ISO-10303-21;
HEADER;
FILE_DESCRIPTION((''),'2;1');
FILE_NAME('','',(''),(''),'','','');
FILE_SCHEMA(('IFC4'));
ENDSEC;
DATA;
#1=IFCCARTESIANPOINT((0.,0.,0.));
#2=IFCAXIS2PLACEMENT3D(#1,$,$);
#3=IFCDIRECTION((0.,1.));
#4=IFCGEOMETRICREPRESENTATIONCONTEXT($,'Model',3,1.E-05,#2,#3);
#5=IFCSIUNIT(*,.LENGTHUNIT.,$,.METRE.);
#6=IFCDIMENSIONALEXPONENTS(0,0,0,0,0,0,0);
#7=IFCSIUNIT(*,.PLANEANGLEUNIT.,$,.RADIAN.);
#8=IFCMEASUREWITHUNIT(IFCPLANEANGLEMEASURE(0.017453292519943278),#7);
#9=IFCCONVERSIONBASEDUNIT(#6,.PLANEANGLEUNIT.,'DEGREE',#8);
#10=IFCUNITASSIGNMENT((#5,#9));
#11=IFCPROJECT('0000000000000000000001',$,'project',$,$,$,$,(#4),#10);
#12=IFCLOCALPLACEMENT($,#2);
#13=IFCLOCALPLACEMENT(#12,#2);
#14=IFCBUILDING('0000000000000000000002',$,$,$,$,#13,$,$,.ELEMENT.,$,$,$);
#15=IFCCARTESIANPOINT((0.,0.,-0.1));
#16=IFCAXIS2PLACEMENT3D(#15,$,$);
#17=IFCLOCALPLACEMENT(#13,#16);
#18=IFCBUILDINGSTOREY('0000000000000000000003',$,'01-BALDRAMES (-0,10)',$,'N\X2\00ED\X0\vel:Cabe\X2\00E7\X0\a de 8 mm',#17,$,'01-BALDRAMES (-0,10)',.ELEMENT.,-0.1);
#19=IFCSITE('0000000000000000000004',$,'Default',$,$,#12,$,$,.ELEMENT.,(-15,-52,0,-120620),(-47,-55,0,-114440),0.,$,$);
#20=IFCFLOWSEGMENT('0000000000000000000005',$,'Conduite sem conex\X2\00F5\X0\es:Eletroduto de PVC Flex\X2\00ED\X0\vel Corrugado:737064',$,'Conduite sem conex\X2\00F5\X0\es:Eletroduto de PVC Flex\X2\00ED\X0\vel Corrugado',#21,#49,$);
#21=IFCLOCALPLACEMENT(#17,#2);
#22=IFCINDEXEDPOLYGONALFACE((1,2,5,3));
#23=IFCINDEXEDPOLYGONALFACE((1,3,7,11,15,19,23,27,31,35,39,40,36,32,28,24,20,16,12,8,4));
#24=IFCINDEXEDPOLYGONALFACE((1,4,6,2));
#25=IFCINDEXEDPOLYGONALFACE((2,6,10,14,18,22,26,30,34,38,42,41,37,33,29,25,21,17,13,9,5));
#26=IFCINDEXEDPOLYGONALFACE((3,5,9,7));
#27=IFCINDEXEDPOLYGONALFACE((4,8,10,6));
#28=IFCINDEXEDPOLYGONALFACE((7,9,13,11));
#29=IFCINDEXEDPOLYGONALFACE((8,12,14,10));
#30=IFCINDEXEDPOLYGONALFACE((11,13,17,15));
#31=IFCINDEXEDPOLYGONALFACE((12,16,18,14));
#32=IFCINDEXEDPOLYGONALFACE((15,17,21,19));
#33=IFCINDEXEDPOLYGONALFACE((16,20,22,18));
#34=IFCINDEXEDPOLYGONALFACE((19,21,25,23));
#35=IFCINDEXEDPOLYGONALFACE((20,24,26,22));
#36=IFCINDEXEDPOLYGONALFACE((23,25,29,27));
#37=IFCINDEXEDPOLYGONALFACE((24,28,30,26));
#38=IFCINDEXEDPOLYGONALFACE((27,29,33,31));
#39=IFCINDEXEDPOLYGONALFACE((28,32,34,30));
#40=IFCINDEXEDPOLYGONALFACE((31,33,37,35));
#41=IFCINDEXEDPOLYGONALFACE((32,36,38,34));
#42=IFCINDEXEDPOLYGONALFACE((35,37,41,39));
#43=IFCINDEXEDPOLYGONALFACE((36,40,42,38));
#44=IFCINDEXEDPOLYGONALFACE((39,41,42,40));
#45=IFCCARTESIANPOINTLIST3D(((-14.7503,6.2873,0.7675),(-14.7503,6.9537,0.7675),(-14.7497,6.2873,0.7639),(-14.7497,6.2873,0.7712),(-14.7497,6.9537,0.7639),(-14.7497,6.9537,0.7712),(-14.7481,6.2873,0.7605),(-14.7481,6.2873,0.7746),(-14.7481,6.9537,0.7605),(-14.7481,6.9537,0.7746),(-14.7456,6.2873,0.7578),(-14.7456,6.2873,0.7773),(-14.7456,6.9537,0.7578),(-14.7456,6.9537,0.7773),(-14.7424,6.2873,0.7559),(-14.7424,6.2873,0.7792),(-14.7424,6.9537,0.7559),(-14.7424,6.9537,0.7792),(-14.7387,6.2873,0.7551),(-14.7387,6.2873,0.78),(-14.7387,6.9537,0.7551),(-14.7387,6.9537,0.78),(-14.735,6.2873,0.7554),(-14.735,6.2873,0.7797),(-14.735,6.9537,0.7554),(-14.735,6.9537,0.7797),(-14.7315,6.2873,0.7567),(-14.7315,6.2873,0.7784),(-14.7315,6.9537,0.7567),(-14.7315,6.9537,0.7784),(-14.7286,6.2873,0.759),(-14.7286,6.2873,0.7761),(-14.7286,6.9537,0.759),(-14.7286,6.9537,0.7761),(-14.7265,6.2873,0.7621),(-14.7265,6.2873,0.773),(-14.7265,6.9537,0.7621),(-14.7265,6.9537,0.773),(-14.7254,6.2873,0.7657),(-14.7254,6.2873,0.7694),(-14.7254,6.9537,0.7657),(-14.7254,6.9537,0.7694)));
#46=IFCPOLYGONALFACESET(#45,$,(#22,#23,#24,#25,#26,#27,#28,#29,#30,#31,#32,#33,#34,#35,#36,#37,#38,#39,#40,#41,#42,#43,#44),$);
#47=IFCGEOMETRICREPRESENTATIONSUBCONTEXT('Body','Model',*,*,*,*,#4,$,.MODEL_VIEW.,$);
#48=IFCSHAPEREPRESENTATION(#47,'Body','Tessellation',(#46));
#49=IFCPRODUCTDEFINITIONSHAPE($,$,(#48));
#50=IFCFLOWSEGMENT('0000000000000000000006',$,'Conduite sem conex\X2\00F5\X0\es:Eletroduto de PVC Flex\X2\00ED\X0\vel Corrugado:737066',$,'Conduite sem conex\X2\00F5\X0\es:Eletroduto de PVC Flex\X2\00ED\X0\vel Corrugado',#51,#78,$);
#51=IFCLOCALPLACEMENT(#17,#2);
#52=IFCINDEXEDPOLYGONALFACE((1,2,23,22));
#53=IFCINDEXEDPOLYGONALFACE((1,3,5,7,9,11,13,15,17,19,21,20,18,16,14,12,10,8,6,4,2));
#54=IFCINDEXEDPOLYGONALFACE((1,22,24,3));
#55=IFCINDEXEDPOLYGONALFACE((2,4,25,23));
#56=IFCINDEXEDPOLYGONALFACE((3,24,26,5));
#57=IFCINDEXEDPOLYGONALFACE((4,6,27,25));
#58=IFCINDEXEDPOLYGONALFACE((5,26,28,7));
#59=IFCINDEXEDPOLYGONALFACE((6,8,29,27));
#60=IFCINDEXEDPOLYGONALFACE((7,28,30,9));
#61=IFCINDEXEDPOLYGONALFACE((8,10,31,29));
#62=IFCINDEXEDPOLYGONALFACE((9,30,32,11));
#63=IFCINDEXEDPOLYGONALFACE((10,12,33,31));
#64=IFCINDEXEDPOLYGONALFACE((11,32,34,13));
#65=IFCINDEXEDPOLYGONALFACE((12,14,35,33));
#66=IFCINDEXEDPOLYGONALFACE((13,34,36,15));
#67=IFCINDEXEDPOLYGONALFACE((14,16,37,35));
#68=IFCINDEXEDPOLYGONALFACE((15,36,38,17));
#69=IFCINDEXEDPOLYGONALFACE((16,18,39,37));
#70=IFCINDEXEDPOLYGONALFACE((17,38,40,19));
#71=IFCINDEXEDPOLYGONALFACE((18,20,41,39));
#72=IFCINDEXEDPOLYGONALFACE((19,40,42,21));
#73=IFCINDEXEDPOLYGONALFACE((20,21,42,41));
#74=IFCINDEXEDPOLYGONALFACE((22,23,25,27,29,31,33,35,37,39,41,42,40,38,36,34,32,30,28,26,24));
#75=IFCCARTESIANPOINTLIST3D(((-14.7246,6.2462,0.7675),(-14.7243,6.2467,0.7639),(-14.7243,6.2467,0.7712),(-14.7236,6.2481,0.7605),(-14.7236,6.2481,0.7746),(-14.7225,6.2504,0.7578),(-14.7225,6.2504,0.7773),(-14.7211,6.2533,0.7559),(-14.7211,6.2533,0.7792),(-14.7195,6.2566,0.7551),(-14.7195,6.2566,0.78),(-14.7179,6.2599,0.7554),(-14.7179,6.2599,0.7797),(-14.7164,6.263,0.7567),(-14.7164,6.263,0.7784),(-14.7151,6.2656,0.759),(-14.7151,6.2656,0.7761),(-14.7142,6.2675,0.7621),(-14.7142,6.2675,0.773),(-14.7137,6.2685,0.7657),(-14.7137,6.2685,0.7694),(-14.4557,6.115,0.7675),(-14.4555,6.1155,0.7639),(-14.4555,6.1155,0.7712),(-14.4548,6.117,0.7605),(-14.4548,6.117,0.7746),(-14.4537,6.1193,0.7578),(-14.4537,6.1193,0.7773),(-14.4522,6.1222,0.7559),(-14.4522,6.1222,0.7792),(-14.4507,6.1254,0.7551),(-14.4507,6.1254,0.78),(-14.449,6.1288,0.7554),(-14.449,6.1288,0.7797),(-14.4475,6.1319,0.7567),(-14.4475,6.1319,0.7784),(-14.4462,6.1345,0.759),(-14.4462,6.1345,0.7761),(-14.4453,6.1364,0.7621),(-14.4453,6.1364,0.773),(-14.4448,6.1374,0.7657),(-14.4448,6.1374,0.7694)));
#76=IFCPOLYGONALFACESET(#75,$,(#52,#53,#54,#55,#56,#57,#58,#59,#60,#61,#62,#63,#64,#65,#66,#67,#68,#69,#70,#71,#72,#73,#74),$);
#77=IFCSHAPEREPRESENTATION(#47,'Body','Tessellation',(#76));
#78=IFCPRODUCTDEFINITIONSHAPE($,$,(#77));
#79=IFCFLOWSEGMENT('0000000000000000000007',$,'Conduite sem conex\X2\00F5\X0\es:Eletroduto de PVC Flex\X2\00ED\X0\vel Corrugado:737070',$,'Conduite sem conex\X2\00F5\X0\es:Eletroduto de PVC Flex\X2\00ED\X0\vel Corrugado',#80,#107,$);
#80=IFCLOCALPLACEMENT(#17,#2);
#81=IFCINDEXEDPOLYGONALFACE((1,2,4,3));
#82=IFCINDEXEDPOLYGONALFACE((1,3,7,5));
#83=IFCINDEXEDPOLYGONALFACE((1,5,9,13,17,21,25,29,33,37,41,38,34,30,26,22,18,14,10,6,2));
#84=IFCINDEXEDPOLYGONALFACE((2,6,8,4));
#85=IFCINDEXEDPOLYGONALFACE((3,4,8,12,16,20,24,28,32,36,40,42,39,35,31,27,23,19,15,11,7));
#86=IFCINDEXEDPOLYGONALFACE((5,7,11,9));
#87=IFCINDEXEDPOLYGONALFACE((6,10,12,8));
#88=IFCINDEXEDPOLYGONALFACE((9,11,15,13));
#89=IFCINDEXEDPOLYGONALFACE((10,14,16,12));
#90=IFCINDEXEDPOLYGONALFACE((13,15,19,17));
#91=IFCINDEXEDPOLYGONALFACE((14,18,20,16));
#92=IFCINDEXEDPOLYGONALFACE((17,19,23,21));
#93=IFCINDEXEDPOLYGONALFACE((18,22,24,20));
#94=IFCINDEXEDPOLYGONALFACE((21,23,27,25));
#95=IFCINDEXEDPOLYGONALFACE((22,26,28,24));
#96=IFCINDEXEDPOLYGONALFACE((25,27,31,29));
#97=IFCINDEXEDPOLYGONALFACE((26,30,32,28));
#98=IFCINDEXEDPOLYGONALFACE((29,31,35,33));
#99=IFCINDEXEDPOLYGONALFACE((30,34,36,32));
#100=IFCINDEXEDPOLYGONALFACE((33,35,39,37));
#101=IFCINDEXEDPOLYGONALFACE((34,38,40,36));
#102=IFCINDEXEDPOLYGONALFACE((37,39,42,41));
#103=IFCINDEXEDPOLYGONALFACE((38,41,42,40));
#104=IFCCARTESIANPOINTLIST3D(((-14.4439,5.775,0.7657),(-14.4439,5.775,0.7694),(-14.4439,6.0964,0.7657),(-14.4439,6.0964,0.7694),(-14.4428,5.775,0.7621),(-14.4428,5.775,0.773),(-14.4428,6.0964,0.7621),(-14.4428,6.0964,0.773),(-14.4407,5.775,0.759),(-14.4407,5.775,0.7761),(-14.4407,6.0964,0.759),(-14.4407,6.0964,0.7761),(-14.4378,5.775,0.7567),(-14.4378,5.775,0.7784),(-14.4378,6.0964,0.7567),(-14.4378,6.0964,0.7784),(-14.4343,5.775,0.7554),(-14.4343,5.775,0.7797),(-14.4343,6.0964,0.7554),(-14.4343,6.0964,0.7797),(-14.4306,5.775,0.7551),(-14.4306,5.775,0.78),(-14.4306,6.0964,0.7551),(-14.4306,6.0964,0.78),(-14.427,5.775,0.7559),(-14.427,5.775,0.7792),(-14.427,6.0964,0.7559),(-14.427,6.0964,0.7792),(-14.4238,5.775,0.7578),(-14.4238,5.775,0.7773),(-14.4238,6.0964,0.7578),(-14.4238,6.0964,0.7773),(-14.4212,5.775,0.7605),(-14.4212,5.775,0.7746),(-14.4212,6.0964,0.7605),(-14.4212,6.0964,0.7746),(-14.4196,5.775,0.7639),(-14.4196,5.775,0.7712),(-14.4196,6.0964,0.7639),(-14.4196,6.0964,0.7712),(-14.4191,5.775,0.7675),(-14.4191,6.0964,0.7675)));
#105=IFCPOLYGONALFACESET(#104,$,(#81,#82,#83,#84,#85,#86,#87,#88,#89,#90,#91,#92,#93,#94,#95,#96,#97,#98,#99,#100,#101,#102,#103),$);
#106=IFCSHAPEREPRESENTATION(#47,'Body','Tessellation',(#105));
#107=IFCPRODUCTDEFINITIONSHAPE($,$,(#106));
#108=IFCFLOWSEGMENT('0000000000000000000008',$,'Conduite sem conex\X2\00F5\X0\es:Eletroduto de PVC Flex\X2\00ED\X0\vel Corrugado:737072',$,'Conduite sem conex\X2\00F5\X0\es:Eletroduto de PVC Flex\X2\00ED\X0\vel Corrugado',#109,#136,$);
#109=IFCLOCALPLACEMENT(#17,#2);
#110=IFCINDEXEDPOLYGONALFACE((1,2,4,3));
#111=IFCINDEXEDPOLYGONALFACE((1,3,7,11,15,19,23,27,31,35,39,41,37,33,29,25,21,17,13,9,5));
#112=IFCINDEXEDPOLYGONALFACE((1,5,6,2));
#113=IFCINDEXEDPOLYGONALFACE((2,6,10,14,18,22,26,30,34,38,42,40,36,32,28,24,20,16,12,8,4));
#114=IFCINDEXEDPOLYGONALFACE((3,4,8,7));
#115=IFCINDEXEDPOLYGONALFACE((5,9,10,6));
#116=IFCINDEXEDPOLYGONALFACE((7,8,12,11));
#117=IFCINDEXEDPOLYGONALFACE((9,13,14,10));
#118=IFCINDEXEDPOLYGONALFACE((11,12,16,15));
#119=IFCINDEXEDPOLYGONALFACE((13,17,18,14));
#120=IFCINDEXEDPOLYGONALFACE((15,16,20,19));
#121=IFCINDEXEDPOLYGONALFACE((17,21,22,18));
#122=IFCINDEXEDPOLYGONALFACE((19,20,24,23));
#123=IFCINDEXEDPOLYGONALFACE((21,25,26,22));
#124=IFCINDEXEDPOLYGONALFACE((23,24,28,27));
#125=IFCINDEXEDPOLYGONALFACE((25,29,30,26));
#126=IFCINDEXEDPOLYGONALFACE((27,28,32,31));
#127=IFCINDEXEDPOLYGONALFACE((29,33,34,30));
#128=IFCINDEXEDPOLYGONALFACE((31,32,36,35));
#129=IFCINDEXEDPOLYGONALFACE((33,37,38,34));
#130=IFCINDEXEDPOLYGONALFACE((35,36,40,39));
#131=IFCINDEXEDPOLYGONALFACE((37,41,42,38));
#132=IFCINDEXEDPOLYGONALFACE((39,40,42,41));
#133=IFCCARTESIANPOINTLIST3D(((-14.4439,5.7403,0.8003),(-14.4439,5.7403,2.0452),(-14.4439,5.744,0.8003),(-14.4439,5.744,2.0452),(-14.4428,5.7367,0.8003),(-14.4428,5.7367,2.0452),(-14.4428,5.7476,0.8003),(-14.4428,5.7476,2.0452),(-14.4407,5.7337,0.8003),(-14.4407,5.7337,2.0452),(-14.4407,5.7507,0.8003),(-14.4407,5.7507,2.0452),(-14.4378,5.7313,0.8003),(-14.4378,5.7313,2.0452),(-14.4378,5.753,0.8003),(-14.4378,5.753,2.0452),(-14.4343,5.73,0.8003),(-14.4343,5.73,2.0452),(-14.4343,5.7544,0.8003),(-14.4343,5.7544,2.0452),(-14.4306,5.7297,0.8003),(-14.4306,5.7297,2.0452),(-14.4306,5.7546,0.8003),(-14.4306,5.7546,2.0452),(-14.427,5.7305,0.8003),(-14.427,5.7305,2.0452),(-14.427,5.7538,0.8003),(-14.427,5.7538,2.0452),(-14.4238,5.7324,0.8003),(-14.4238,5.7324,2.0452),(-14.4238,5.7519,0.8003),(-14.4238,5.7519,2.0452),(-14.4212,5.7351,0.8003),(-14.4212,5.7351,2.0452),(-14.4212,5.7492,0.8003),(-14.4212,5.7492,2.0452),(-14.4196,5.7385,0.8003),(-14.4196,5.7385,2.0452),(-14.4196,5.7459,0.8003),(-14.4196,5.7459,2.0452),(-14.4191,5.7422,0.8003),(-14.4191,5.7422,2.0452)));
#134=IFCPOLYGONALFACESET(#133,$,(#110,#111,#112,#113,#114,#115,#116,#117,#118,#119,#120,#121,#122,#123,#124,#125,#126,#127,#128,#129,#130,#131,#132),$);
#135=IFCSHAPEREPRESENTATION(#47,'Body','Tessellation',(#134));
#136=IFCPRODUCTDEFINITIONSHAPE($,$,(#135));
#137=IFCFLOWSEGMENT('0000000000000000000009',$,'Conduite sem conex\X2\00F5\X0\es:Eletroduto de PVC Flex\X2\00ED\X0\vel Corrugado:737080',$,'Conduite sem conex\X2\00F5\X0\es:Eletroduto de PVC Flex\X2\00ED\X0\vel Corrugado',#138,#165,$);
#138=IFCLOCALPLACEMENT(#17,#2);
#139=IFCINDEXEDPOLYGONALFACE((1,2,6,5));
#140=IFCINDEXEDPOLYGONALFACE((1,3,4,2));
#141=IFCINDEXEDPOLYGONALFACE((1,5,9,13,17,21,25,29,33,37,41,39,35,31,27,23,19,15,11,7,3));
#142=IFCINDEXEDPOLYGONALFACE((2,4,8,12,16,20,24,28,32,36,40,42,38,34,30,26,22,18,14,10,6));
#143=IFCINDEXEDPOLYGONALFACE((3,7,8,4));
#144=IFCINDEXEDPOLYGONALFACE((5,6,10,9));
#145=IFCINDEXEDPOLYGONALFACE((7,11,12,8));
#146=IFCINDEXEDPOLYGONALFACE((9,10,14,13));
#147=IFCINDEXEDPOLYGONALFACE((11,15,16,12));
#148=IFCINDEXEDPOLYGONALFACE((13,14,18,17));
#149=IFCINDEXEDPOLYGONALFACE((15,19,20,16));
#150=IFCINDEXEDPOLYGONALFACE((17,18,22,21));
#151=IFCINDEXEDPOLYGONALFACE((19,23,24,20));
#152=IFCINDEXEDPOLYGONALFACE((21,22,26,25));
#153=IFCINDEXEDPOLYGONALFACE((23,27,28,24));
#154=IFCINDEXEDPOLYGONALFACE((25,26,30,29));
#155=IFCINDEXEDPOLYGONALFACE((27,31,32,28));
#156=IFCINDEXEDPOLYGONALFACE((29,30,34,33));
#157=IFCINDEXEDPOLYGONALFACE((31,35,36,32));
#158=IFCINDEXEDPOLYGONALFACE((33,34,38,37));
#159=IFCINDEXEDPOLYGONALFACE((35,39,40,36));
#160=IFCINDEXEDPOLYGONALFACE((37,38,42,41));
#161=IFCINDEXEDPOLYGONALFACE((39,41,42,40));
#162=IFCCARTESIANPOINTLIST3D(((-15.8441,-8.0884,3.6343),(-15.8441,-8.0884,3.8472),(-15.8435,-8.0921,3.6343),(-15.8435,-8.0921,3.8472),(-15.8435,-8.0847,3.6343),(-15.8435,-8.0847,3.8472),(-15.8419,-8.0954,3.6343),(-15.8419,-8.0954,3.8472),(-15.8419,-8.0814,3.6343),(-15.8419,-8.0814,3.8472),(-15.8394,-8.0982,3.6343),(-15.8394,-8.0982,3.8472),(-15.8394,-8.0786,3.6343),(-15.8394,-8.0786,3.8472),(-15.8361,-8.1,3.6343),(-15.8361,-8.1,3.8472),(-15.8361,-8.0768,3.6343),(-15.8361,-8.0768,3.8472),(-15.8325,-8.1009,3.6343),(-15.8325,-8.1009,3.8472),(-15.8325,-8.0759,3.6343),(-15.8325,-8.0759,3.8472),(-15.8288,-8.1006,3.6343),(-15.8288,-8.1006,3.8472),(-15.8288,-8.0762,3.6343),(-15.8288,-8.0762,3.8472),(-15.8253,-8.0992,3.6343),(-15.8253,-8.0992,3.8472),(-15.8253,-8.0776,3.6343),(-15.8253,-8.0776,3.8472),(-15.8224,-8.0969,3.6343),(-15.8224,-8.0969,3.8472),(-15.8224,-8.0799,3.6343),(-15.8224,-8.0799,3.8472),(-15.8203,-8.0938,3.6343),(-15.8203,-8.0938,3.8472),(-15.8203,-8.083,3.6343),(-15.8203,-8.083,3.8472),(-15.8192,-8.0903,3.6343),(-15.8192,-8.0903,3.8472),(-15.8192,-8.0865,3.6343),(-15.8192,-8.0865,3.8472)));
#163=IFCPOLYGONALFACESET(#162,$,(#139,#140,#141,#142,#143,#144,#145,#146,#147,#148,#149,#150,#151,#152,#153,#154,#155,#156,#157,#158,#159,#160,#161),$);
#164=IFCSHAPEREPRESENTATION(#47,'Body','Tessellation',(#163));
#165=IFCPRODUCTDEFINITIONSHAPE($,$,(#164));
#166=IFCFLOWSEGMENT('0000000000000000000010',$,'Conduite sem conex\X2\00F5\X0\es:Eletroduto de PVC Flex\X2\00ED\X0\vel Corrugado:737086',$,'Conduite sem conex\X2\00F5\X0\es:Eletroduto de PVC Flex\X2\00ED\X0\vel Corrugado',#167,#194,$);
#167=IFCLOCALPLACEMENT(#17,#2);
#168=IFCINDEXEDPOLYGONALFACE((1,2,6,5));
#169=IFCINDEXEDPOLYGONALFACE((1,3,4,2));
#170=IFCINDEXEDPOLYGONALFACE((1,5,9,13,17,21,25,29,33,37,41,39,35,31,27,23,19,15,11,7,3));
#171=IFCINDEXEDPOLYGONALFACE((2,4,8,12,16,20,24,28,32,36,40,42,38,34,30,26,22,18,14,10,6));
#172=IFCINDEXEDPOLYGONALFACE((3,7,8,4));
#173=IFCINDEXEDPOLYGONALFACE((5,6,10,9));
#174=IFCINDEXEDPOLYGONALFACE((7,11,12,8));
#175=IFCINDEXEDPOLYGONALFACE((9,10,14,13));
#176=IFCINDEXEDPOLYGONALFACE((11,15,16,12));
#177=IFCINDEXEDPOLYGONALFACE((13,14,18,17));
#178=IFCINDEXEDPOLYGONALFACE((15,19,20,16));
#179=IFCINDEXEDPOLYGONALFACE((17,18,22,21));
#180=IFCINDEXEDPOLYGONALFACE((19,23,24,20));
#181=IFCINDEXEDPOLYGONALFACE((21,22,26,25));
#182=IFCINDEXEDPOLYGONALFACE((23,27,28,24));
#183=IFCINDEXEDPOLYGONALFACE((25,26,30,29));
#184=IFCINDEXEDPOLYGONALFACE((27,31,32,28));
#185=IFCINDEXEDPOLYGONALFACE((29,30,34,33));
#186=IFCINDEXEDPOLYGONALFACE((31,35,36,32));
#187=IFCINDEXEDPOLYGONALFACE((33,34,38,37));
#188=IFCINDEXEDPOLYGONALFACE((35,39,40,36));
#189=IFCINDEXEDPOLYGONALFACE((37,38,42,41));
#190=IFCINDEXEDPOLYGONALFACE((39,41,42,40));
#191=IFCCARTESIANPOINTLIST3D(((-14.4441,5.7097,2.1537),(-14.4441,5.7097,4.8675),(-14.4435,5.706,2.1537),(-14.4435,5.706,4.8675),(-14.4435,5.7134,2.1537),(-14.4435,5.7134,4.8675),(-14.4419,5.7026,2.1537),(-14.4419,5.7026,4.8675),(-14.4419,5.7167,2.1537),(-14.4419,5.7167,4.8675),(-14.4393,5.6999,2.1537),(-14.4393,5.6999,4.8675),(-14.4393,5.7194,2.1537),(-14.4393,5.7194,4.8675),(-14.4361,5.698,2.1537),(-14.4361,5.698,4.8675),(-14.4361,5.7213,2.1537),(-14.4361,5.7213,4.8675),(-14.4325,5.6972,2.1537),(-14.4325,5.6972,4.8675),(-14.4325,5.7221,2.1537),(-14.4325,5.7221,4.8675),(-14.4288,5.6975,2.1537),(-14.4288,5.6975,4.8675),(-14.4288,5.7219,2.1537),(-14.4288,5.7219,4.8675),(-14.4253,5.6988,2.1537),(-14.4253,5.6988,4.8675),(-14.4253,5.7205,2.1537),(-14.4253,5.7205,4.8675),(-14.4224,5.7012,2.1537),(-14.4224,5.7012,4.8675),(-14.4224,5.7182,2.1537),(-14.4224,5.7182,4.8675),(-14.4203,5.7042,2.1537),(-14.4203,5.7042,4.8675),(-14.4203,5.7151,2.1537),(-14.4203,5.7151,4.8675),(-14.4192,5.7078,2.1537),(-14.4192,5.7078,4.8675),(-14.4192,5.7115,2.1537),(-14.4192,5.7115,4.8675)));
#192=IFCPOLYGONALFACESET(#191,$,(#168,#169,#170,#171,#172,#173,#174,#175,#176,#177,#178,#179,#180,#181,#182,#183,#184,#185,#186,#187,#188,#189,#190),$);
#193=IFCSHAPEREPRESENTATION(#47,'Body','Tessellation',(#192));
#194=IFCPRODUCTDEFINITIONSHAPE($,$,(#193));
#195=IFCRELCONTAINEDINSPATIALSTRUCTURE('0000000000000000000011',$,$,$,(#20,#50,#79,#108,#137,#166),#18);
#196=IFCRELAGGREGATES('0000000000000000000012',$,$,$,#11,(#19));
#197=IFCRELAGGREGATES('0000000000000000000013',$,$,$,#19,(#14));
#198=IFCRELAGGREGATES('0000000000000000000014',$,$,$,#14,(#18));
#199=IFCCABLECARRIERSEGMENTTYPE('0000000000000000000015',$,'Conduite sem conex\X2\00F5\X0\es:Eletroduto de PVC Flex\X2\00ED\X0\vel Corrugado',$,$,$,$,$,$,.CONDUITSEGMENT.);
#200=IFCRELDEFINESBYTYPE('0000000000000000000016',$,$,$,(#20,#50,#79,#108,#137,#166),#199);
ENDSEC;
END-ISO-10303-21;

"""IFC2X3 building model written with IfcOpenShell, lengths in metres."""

from ifc_helpers import new_model, entity, si_unit, converted_unit, direction, frame, frame_2d, origin, origin_2d_with_axis, place, context, subcontext, project, spatial, circle, extrude, type_object, element, save


model = new_model("IFC2X3")

# Units and contexts
model_context = context("Model", 3, precision=1e-05, world=origin(), true_north=direction((0.0, 1.0)))
body_context = subcontext(model_context, "Body", "Model", "MODEL_VIEW")
ifc_project = project(units=[si_unit("LENGTHUNIT", "METRE"), converted_unit("PLANEANGLEUNIT", "DEGREE", entity("IfcPlaneAngleMeasure", 0.017453292519943278), si_unit("PLANEANGLEUNIT", "RADIAN"), dimensions=[0, 0, 0, 0, 0, 0, 0])], contexts=[model_context])

# Site, building, storey
site_placement = place(None, origin())
site = spatial("IfcSite", under=ifc_project, at=site_placement, Name="Default", CompositionType="ELEMENT", RefLatitude=(-15, -52, 0, -120620), RefLongitude=(-47, -55, 0, -114440), RefElevation=0.0)
building_placement = place(site_placement, origin())
building = spatial("IfcBuilding", under=site, at=building_placement, CompositionType="ELEMENT")
storey_placement = place(building_placement, frame((0.0, 0.0, -0.1)))
storey = spatial("IfcBuildingStorey", under=building, at=storey_placement, Name="01-BALDRAMES (-0,10)", ObjectType="Nível:Cabeça de 8 mm", LongName="01-BALDRAMES (-0,10)", CompositionType="ELEMENT", Elevation=-0.1)

# Flow segments
cable_carrier_segment_type = type_object("IfcCableCarrierSegmentType", Name="Conduite sem conexões:Eletroduto de PVC Flexível Corrugado", PredefinedType="CONDUITSEGMENT")
flow_segment_1_placement = place(storey_placement, origin())
element("IfcFlowSegment", 1, at=flow_segment_1_placement, inside=storey, type_object=cable_carrier_segment_type, Name="Conduite sem conexões:Eletroduto de PVC Flexível Corrugado:737064", ObjectType="Conduite sem conexões:Eletroduto de PVC Flexível Corrugado", context=body_context, shape_type="SweptSolid", body=[
    extrude(circle(Radius=0.0125, at=frame_2d((0.0, 0.0), x_axis=(1.0, 0.0))), frame((-14.7378, 6.2873, 0.7675), z_axis=(0.0, 1.0, 0.0), x_axis=(-1.0, 0.0, 0.0)), (0.0, 0.0, 1.0), 0.6664),
])
flow_segment_2_placement = place(storey_placement, origin())
element("IfcFlowSegment", 2, at=flow_segment_2_placement, inside=storey, type_object=cable_carrier_segment_type, Name="Conduite sem conexões:Eletroduto de PVC Flexível Corrugado:737066", ObjectType="Conduite sem conexões:Eletroduto de PVC Flexível Corrugado", context=body_context, shape_type="SweptSolid", body=[
    extrude(circle(Radius=0.0125, at=origin_2d_with_axis()), frame((-14.4502, 6.1263, 0.7675), z_axis=(-0.898794, 0.438371, 0.0), x_axis=(-0.438371, -0.898794, 0.0)), (0.0, 0.0, 1.0), 0.2991),
])
flow_segment_3_placement = place(storey_placement, origin())
element("IfcFlowSegment", 3, at=flow_segment_3_placement, inside=storey, type_object=cable_carrier_segment_type, Name="Conduite sem conexões:Eletroduto de PVC Flexível Corrugado:737070", ObjectType="Conduite sem conexões:Eletroduto de PVC Flexível Corrugado", context=body_context, shape_type="SweptSolid", body=[
    extrude(circle(Radius=0.0125, at=origin_2d_with_axis()), frame((-14.4316, 5.775, 0.7675), z_axis=(0.0, 1.0, 0.0), x_axis=(1.0, 0.0, 0.0)), (0.0, 0.0, 1.0), 0.3214),
])
flow_segment_4_placement = place(storey_placement, origin())
element("IfcFlowSegment", 4, at=flow_segment_4_placement, inside=storey, type_object=cable_carrier_segment_type, Name="Conduite sem conexões:Eletroduto de PVC Flexível Corrugado:737072", ObjectType="Conduite sem conexões:Eletroduto de PVC Flexível Corrugado", context=body_context, shape_type="SweptSolid", body=[
    extrude(circle(Radius=0.0125, at=frame_2d((0.0, 0.0), x_axis=(1.0, 0.0))), frame((-14.4316, 5.7422, 0.8003)), (0.0, 0.0, 1.0), 1.2449),
])
flow_segment_5_placement = place(storey_placement, origin())
element("IfcFlowSegment", 5, at=flow_segment_5_placement, inside=storey, type_object=cable_carrier_segment_type, Name="Conduite sem conexões:Eletroduto de PVC Flexível Corrugado:737080", ObjectType="Conduite sem conexões:Eletroduto de PVC Flexível Corrugado", context=body_context, shape_type="SweptSolid", body=[
    extrude(circle(Radius=0.0125, at=origin_2d_with_axis()), frame((-15.8316, -8.0884, 3.6343), z_axis=(0.0, 0.0, 1.0), x_axis=(-1.0, 0.0, 0.0)), (0.0, 0.0, 1.0), 0.213),
])
flow_segment_6_placement = place(storey_placement, origin())
element("IfcFlowSegment", 6, at=flow_segment_6_placement, inside=storey, type_object=cable_carrier_segment_type, Name="Conduite sem conexões:Eletroduto de PVC Flexível Corrugado:737086", ObjectType="Conduite sem conexões:Eletroduto de PVC Flexível Corrugado", context=body_context, shape_type="SweptSolid", body=[
    extrude(circle(Radius=0.0125, at=origin_2d_with_axis()), frame((-14.4316, 5.7097, 2.1537), z_axis=(0.0, 0.0, 1.0), x_axis=(-1.0, 0.0, 0.0)), (0.0, 0.0, 1.0), 2.7138),
])

save(model, "model.ifc")
